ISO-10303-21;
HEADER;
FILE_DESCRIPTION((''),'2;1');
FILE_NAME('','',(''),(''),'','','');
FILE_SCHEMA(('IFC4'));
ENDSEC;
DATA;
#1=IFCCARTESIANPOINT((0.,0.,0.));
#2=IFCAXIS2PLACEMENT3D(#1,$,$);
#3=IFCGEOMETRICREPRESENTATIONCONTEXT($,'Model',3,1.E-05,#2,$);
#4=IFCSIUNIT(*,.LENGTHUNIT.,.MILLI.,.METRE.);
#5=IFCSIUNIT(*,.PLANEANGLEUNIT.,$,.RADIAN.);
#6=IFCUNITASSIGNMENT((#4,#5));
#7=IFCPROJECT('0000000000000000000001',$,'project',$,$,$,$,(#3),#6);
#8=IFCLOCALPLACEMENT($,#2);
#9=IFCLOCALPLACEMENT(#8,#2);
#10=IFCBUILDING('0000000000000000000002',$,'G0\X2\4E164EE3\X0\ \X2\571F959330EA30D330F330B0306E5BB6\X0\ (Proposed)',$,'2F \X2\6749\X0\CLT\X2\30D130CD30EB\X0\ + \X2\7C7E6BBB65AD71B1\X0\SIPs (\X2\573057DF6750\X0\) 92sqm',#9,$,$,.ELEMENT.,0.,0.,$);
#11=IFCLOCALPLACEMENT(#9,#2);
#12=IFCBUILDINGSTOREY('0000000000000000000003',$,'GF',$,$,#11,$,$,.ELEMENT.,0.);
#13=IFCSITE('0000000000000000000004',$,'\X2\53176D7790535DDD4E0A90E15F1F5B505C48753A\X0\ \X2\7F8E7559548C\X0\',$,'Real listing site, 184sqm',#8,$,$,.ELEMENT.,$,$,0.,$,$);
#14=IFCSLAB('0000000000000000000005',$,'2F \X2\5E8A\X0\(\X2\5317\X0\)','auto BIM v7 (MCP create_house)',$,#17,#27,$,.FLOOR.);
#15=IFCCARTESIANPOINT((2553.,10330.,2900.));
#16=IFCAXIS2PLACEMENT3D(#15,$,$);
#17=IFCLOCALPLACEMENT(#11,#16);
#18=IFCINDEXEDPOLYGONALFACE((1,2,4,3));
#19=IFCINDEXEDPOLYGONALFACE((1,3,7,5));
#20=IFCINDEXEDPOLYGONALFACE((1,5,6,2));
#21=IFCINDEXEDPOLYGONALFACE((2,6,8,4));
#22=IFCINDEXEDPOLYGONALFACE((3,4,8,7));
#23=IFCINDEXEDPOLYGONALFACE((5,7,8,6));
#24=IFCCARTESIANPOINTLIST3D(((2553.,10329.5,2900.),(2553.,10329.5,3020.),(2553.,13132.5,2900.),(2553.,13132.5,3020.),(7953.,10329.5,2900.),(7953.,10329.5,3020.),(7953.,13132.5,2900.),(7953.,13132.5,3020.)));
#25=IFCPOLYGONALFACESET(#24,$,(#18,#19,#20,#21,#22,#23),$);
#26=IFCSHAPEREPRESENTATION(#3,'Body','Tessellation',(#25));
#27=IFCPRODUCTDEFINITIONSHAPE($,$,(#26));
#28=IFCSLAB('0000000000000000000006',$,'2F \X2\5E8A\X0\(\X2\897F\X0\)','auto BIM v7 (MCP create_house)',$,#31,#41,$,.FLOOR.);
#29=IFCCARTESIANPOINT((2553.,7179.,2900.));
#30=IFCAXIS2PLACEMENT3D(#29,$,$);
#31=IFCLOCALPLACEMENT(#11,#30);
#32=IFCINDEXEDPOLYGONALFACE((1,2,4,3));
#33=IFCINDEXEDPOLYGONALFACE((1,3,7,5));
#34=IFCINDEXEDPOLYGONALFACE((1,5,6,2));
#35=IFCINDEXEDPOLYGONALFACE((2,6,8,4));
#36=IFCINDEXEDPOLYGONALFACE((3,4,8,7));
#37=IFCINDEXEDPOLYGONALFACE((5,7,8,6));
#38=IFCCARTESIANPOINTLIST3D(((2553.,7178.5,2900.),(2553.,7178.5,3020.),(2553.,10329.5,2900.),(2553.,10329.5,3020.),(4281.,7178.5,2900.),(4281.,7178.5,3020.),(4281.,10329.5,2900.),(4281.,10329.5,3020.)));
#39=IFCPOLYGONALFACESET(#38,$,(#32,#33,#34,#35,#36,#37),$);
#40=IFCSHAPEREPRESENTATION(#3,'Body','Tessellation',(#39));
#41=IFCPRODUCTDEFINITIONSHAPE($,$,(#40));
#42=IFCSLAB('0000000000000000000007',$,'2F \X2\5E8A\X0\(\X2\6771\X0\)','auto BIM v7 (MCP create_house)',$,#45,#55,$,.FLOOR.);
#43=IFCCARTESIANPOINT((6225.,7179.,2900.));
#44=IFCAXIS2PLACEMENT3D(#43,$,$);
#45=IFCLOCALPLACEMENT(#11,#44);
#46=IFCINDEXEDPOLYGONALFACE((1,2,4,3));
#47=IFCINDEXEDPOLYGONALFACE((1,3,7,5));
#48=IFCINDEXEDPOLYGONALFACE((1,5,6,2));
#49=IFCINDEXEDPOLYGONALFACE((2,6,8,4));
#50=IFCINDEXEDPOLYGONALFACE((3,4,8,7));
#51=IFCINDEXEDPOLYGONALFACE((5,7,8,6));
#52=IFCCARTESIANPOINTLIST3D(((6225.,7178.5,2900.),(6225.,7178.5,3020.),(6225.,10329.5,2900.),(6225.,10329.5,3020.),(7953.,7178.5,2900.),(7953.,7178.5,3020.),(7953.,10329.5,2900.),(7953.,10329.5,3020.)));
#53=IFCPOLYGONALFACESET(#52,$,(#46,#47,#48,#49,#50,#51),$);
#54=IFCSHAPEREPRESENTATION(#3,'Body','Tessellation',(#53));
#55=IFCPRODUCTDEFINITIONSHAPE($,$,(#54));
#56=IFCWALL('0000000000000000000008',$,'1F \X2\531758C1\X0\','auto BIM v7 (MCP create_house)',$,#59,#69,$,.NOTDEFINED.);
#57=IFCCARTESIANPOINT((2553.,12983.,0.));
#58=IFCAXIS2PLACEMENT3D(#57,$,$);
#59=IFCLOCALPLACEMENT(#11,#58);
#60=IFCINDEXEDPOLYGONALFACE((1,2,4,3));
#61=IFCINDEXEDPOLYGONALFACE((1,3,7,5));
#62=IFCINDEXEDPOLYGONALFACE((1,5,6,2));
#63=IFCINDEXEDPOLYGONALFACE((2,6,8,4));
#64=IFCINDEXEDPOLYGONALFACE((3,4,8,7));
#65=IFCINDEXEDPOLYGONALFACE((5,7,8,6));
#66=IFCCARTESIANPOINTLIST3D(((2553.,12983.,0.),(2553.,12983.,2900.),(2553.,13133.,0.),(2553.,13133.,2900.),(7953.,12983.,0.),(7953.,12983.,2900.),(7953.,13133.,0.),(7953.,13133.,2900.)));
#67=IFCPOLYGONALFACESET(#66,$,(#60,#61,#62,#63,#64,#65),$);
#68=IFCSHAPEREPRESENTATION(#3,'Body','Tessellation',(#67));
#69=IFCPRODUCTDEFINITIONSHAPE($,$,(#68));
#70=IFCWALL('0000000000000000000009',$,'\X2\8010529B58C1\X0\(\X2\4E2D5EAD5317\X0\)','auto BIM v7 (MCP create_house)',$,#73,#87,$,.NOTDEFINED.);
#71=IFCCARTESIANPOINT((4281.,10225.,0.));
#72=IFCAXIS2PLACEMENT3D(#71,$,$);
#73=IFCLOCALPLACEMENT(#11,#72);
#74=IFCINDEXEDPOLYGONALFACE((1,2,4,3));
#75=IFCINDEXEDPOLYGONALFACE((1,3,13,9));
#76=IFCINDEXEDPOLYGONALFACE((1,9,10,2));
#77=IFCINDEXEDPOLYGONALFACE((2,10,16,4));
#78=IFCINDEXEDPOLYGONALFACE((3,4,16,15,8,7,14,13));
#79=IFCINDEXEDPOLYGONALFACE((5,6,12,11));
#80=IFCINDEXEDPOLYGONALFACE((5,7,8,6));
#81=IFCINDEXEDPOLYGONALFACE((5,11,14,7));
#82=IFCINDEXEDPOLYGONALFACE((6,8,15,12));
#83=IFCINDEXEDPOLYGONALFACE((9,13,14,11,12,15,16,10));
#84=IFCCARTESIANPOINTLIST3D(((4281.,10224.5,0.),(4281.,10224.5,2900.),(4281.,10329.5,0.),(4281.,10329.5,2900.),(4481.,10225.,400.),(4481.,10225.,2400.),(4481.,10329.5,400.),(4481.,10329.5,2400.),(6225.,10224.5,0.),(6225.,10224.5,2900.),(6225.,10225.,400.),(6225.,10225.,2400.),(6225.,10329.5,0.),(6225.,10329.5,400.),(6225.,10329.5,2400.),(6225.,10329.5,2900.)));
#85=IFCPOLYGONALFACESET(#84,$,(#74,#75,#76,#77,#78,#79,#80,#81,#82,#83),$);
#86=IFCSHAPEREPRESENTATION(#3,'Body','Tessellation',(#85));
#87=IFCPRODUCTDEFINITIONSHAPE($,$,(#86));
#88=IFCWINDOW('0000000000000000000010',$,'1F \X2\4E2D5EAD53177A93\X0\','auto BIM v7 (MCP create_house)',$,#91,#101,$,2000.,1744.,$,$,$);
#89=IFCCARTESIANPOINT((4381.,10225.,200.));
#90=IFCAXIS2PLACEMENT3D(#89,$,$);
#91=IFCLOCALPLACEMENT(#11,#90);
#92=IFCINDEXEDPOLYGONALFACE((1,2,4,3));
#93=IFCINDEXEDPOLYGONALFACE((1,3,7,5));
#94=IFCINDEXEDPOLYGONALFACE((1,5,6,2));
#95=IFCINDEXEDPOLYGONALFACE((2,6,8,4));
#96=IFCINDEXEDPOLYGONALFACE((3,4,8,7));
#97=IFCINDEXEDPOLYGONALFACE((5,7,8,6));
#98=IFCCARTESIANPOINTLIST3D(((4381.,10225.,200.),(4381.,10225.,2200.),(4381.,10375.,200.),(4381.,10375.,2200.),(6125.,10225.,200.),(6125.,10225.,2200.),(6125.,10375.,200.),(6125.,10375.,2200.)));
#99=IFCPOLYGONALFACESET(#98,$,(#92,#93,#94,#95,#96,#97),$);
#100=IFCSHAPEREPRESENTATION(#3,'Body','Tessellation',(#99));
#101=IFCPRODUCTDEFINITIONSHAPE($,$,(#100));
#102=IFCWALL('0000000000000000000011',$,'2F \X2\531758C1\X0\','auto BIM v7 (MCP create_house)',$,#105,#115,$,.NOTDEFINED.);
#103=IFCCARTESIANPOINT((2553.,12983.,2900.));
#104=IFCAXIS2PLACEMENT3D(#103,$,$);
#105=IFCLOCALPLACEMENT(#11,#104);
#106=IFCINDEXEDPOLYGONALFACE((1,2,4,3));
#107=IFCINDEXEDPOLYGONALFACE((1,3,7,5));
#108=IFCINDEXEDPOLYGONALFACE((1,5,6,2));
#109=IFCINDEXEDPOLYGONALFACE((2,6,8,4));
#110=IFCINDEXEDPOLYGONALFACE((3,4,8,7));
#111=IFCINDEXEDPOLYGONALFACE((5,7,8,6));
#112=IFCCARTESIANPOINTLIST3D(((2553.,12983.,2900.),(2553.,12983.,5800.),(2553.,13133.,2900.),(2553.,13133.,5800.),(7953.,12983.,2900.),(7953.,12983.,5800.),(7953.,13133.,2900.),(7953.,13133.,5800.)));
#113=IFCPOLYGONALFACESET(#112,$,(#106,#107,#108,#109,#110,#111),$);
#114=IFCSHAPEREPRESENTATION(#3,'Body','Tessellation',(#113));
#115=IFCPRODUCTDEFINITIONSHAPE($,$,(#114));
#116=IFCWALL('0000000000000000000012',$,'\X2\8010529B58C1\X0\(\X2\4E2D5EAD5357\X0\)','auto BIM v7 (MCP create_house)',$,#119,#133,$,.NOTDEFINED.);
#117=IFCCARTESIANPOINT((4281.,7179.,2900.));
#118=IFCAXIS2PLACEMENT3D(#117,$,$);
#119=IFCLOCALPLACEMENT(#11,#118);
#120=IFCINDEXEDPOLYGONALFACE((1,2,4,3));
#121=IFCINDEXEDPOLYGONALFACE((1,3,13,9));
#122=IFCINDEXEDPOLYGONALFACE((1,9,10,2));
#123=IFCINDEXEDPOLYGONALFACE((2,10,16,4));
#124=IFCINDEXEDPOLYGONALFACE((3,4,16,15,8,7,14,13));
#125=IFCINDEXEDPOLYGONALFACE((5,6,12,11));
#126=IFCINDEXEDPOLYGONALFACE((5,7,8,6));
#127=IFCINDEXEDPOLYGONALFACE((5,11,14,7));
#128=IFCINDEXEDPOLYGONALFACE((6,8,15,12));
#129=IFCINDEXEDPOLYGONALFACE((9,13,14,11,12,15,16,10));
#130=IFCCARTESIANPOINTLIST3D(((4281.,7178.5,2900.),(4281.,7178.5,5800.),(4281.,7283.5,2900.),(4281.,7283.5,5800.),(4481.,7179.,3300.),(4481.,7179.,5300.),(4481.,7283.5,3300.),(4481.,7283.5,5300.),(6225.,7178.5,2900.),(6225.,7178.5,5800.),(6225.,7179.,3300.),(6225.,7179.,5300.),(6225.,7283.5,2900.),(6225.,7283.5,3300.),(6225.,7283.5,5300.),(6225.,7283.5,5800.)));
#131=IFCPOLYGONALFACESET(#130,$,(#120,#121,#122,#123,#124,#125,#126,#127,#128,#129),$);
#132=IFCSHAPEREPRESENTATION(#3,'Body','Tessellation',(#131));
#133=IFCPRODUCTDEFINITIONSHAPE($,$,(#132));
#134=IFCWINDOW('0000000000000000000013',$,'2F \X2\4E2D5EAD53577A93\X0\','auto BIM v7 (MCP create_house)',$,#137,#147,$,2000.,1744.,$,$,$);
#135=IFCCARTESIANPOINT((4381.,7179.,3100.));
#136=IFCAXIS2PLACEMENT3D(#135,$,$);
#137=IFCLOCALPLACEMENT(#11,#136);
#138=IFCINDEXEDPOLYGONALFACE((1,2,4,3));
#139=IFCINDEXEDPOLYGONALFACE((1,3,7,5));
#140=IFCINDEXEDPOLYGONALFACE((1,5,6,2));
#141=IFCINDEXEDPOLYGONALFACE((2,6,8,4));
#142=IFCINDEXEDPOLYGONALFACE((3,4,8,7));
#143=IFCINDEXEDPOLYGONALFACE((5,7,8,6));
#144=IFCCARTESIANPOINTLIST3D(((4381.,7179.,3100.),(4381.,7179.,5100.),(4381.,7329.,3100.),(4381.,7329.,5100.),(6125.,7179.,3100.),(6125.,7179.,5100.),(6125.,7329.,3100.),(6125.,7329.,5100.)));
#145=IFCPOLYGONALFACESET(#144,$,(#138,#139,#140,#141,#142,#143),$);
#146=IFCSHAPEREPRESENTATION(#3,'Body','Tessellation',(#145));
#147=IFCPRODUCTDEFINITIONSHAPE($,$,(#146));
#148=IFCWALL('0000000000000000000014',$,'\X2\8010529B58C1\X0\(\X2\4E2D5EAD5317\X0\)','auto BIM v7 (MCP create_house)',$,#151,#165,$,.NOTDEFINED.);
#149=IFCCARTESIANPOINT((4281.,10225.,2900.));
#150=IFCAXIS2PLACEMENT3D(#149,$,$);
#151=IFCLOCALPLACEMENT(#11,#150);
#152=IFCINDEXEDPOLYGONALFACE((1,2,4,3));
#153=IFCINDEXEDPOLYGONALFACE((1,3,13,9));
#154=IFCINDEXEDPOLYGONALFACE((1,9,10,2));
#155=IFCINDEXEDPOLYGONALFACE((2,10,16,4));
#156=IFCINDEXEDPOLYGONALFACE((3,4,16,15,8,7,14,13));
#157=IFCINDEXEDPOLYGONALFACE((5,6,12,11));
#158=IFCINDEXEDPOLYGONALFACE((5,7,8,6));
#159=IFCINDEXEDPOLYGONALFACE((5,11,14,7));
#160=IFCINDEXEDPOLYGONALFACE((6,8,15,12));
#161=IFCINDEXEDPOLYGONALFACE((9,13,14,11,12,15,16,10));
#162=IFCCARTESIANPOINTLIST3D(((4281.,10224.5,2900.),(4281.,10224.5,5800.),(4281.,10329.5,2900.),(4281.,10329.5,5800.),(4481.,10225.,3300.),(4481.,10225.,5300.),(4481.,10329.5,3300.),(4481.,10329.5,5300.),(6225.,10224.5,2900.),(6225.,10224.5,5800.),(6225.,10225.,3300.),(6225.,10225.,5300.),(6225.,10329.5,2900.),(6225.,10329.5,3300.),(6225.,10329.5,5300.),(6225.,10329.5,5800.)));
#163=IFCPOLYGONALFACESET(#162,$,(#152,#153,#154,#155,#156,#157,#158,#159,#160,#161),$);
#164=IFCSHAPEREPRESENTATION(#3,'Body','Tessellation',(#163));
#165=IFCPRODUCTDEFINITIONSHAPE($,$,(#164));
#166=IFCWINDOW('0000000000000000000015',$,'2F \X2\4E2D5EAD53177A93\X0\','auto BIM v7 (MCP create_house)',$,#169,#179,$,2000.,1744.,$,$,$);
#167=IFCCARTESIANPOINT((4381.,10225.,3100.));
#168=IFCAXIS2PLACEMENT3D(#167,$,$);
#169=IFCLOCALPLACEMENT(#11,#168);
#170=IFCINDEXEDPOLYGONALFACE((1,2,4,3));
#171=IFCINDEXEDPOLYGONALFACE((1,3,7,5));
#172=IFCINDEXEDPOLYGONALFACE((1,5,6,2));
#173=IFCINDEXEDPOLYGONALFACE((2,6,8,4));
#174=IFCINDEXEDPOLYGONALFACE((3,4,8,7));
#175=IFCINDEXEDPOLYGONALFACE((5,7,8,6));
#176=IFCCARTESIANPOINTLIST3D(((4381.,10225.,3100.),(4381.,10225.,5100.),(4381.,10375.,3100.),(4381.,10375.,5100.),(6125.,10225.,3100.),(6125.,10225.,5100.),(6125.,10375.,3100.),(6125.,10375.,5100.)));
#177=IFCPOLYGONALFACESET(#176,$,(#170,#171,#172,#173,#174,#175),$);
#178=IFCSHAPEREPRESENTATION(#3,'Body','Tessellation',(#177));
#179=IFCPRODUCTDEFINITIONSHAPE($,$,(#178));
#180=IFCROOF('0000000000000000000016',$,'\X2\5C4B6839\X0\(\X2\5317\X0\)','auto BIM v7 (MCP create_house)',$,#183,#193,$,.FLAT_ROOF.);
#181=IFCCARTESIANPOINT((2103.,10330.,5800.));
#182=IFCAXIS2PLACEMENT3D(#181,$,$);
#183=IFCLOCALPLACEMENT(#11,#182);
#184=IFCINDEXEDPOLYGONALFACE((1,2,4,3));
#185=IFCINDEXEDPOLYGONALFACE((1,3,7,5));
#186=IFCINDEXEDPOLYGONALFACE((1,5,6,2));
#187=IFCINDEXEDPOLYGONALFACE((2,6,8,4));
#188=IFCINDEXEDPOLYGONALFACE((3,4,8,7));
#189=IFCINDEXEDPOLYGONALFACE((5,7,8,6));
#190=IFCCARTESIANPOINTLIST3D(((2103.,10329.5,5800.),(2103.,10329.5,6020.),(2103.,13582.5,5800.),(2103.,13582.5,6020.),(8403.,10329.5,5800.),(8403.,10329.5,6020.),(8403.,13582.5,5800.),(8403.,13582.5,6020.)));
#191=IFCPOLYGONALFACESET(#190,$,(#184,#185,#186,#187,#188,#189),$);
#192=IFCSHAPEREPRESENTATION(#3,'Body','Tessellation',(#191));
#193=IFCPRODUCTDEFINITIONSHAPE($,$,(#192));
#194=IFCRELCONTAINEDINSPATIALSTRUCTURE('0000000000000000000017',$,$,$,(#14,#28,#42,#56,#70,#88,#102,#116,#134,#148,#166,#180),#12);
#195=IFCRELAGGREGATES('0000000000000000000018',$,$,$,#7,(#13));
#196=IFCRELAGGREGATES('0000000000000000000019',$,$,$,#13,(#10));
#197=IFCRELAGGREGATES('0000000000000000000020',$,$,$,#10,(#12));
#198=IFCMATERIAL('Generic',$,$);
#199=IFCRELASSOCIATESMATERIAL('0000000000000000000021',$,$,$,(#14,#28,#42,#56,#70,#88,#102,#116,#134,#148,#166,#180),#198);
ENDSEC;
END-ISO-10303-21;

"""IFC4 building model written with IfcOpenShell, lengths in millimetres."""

from ifc_helpers import new_model, si_unit, frame, frame_2d, origin, place, context, project, spatial, rectangle, extrude, material, element, fill, save


model = new_model("IFC4")

# Units and contexts
model_context = context("Model", 3, precision=1e-05, world=origin())
ifc_project = project(units=[si_unit("LENGTHUNIT", "METRE", prefix="MILLI"), si_unit("PLANEANGLEUNIT", "RADIAN")], contexts=[model_context])

# Site, building, storey
site_placement = place(None, origin())
site = spatial("IfcSite", under=ifc_project, at=site_placement, Name="北海道川上郡弟子屈町 美留和", ObjectType="Real listing site, 184sqm", CompositionType="ELEMENT", RefElevation=0.0)
building_placement = place(site_placement, origin())
building = spatial("IfcBuilding", under=site, at=building_placement, Name="G0世代 土間リビングの家 (Proposed)", ObjectType="2F 杉CLTパネル + 籾殻断熱SIPs (地域材) 92sqm", CompositionType="ELEMENT", ElevationOfRefHeight=0.0, ElevationOfTerrain=0.0)
storey_placement = place(building_placement, origin())
storey = spatial("IfcBuildingStorey", under=building, at=storey_placement, Name="GF", CompositionType="ELEMENT", Elevation=0.0)

# Slabs
ifc_material = material(Name="Generic")
slab_1_placement = place(storey_placement, frame((2553.0, 10330.0, 2900.0)))
element("IfcSlab", 1, at=slab_1_placement, inside=storey, material=ifc_material, Name="2F 床(北)", Description="auto BIM v7 (MCP create_house)", PredefinedType="FLOOR", context=model_context, shape_type="SweptSolid", body=[
    extrude(rectangle(XDim=5400.0, YDim=2803.0, at=frame_2d((2700.0, 1401.0))), frame((2553.0, 10330.0, 2900.0)), (0.0, 0.0, 1.0), 120.0),
])
slab_2_placement = place(storey_placement, frame((2553.0, 7179.0, 2900.0)))
element("IfcSlab", 2, at=slab_2_placement, inside=storey, material=ifc_material, Name="2F 床(西)", Description="auto BIM v7 (MCP create_house)", PredefinedType="FLOOR", context=model_context, shape_type="SweptSolid", body=[
    extrude(rectangle(XDim=1728.0, YDim=3151.0, at=frame_2d((864.0, 1575.0))), frame((2553.0, 7179.0, 2900.0)), (0.0, 0.0, 1.0), 120.0),
])
slab_3_placement = place(storey_placement, frame((6225.0, 7179.0, 2900.0)))
element("IfcSlab", 3, at=slab_3_placement, inside=storey, material=ifc_material, Name="2F 床(東)", Description="auto BIM v7 (MCP create_house)", PredefinedType="FLOOR", context=model_context, shape_type="SweptSolid", body=[
    extrude(rectangle(XDim=1728.0, YDim=3151.0, at=frame_2d((864.0, 1575.0))), frame((6225.0, 7179.0, 2900.0)), (0.0, 0.0, 1.0), 120.0),
])

# Wall
wall_1_placement = place(storey_placement, frame((2553.0, 12983.0, 0.0)))
element("IfcWall", 4, at=wall_1_placement, inside=storey, material=ifc_material, Name="1F 北壁", Description="auto BIM v7 (MCP create_house)", PredefinedType="NOTDEFINED", context=model_context, shape_type="SweptSolid", body=[
    extrude(rectangle(XDim=5400.0, YDim=150.0, at=frame_2d((2700.0, 75.0))), frame((2553.0, 12983.0, 0.0)), (0.0, 0.0, 1.0), 2900.0),
])

# Wall, opening, window
wall_2_placement = place(storey_placement, frame((4281.0, 10225.0, 0.0)))
wall_2 = element("IfcWall", 5, at=wall_2_placement, inside=storey, material=ifc_material, Name="耐力壁(中庭北)", Description="auto BIM v7 (MCP create_house)", PredefinedType="NOTDEFINED", context=model_context, shape_type="SweptSolid", body=[
    extrude(rectangle(XDim=1944.0, YDim=105.0, at=frame_2d((972.0, 52.0))), frame((4281.0, 10225.0, 0.0)), (0.0, 0.0, 1.0), 2900.0),
])
opening_1_placement = place(storey_placement, frame((4381.0, 10225.0, 200.0)))
opening_1 = element("IfcOpeningElement", 6, at=opening_1_placement, cuts=wall_2, PredefinedType="NOTDEFINED", context=model_context, shape_type="SweptSolid", body=[
    extrude(rectangle(XDim=1744.0, YDim=150.0, at=frame_2d((872.0, 75.0))), frame((4381.0, 10225.0, 200.0)), (0.0, 0.0, 1.0), 2000.0),
])
window_1_placement = place(storey_placement, frame((4381.0, 10225.0, 200.0)))
window_1 = element("IfcWindow", 7, at=window_1_placement, inside=storey, material=ifc_material, Name="1F 中庭北窓", Description="auto BIM v7 (MCP create_house)", OverallHeight=2000.0, OverallWidth=1744.0, context=model_context, shape_type="SweptSolid", body=[
    extrude(rectangle(XDim=1744.0, YDim=150.0, at=frame_2d((872.0, 75.0))), frame((4381.0, 10225.0, 200.0)), (0.0, 0.0, 1.0), 2000.0),
])
fill(opening_1, window_1)

# Wall
wall_3_placement = place(storey_placement, frame((2553.0, 12983.0, 2900.0)))
element("IfcWall", 8, at=wall_3_placement, inside=storey, material=ifc_material, Name="2F 北壁", Description="auto BIM v7 (MCP create_house)", PredefinedType="NOTDEFINED", context=model_context, shape_type="SweptSolid", body=[
    extrude(rectangle(XDim=5400.0, YDim=150.0, at=frame_2d((2700.0, 75.0))), frame((2553.0, 12983.0, 2900.0)), (0.0, 0.0, 1.0), 2900.0),
])

# Walls, openings, windows
wall_4_placement = place(storey_placement, frame((4281.0, 7179.0, 2900.0)))
wall_4 = element("IfcWall", 9, at=wall_4_placement, inside=storey, material=ifc_material, Name="耐力壁(中庭南)", Description="auto BIM v7 (MCP create_house)", PredefinedType="NOTDEFINED", context=model_context, shape_type="SweptSolid", body=[
    extrude(rectangle(XDim=1944.0, YDim=105.0, at=frame_2d((972.0, 52.0))), frame((4281.0, 7179.0, 2900.0)), (0.0, 0.0, 1.0), 2900.0),
])
opening_2_placement = place(storey_placement, frame((4381.0, 7179.0, 3100.0)))
opening_2 = element("IfcOpeningElement", 10, at=opening_2_placement, cuts=wall_4, PredefinedType="NOTDEFINED", context=model_context, shape_type="SweptSolid", body=[
    extrude(rectangle(XDim=1744.0, YDim=150.0, at=frame_2d((872.0, 75.0))), frame((4381.0, 7179.0, 3100.0)), (0.0, 0.0, 1.0), 2000.0),
])
window_2_placement = place(storey_placement, frame((4381.0, 7179.0, 3100.0)))
window_2 = element("IfcWindow", 11, at=window_2_placement, inside=storey, material=ifc_material, Name="2F 中庭南窓", Description="auto BIM v7 (MCP create_house)", OverallHeight=2000.0, OverallWidth=1744.0, context=model_context, shape_type="SweptSolid", body=[
    extrude(rectangle(XDim=1744.0, YDim=150.0, at=frame_2d((872.0, 75.0))), frame((4381.0, 7179.0, 3100.0)), (0.0, 0.0, 1.0), 2000.0),
])
fill(opening_2, window_2)
wall_5_placement = place(storey_placement, frame((4281.0, 10225.0, 2900.0)))
wall_5 = element("IfcWall", 12, at=wall_5_placement, inside=storey, material=ifc_material, Name="耐力壁(中庭北)", Description="auto BIM v7 (MCP create_house)", PredefinedType="NOTDEFINED", context=model_context, shape_type="SweptSolid", body=[
    extrude(rectangle(XDim=1944.0, YDim=105.0, at=frame_2d((972.0, 52.0))), frame((4281.0, 10225.0, 2900.0)), (0.0, 0.0, 1.0), 2900.0),
])
opening_3_placement = place(storey_placement, frame((4381.0, 10225.0, 3100.0)))
opening_3 = element("IfcOpeningElement", 13, at=opening_3_placement, cuts=wall_5, PredefinedType="NOTDEFINED", context=model_context, shape_type="SweptSolid", body=[
    extrude(rectangle(XDim=1744.0, YDim=150.0, at=frame_2d((872.0, 75.0))), frame((4381.0, 10225.0, 3100.0)), (0.0, 0.0, 1.0), 2000.0),
])
window_3_placement = place(storey_placement, frame((4381.0, 10225.0, 3100.0)))
window_3 = element("IfcWindow", 14, at=window_3_placement, inside=storey, material=ifc_material, Name="2F 中庭北窓", Description="auto BIM v7 (MCP create_house)", OverallHeight=2000.0, OverallWidth=1744.0, context=model_context, shape_type="SweptSolid", body=[
    extrude(rectangle(XDim=1744.0, YDim=150.0, at=frame_2d((872.0, 75.0))), frame((4381.0, 10225.0, 3100.0)), (0.0, 0.0, 1.0), 2000.0),
])
fill(opening_3, window_3)

# Roof
roof_1_placement = place(storey_placement, frame((2103.0, 10330.0, 5800.0)))
element("IfcRoof", 15, at=roof_1_placement, inside=storey, material=ifc_material, Name="屋根(北)", Description="auto BIM v7 (MCP create_house)", PredefinedType="FLAT_ROOF", context=model_context, shape_type="SweptSolid", body=[
    extrude(rectangle(XDim=6300.0, YDim=3253.0, at=frame_2d((3150.0, 1626.0))), frame((2103.0, 10330.0, 5800.0)), (0.0, 0.0, 1.0), 220.0),
])

save(model, "model.ifc")
